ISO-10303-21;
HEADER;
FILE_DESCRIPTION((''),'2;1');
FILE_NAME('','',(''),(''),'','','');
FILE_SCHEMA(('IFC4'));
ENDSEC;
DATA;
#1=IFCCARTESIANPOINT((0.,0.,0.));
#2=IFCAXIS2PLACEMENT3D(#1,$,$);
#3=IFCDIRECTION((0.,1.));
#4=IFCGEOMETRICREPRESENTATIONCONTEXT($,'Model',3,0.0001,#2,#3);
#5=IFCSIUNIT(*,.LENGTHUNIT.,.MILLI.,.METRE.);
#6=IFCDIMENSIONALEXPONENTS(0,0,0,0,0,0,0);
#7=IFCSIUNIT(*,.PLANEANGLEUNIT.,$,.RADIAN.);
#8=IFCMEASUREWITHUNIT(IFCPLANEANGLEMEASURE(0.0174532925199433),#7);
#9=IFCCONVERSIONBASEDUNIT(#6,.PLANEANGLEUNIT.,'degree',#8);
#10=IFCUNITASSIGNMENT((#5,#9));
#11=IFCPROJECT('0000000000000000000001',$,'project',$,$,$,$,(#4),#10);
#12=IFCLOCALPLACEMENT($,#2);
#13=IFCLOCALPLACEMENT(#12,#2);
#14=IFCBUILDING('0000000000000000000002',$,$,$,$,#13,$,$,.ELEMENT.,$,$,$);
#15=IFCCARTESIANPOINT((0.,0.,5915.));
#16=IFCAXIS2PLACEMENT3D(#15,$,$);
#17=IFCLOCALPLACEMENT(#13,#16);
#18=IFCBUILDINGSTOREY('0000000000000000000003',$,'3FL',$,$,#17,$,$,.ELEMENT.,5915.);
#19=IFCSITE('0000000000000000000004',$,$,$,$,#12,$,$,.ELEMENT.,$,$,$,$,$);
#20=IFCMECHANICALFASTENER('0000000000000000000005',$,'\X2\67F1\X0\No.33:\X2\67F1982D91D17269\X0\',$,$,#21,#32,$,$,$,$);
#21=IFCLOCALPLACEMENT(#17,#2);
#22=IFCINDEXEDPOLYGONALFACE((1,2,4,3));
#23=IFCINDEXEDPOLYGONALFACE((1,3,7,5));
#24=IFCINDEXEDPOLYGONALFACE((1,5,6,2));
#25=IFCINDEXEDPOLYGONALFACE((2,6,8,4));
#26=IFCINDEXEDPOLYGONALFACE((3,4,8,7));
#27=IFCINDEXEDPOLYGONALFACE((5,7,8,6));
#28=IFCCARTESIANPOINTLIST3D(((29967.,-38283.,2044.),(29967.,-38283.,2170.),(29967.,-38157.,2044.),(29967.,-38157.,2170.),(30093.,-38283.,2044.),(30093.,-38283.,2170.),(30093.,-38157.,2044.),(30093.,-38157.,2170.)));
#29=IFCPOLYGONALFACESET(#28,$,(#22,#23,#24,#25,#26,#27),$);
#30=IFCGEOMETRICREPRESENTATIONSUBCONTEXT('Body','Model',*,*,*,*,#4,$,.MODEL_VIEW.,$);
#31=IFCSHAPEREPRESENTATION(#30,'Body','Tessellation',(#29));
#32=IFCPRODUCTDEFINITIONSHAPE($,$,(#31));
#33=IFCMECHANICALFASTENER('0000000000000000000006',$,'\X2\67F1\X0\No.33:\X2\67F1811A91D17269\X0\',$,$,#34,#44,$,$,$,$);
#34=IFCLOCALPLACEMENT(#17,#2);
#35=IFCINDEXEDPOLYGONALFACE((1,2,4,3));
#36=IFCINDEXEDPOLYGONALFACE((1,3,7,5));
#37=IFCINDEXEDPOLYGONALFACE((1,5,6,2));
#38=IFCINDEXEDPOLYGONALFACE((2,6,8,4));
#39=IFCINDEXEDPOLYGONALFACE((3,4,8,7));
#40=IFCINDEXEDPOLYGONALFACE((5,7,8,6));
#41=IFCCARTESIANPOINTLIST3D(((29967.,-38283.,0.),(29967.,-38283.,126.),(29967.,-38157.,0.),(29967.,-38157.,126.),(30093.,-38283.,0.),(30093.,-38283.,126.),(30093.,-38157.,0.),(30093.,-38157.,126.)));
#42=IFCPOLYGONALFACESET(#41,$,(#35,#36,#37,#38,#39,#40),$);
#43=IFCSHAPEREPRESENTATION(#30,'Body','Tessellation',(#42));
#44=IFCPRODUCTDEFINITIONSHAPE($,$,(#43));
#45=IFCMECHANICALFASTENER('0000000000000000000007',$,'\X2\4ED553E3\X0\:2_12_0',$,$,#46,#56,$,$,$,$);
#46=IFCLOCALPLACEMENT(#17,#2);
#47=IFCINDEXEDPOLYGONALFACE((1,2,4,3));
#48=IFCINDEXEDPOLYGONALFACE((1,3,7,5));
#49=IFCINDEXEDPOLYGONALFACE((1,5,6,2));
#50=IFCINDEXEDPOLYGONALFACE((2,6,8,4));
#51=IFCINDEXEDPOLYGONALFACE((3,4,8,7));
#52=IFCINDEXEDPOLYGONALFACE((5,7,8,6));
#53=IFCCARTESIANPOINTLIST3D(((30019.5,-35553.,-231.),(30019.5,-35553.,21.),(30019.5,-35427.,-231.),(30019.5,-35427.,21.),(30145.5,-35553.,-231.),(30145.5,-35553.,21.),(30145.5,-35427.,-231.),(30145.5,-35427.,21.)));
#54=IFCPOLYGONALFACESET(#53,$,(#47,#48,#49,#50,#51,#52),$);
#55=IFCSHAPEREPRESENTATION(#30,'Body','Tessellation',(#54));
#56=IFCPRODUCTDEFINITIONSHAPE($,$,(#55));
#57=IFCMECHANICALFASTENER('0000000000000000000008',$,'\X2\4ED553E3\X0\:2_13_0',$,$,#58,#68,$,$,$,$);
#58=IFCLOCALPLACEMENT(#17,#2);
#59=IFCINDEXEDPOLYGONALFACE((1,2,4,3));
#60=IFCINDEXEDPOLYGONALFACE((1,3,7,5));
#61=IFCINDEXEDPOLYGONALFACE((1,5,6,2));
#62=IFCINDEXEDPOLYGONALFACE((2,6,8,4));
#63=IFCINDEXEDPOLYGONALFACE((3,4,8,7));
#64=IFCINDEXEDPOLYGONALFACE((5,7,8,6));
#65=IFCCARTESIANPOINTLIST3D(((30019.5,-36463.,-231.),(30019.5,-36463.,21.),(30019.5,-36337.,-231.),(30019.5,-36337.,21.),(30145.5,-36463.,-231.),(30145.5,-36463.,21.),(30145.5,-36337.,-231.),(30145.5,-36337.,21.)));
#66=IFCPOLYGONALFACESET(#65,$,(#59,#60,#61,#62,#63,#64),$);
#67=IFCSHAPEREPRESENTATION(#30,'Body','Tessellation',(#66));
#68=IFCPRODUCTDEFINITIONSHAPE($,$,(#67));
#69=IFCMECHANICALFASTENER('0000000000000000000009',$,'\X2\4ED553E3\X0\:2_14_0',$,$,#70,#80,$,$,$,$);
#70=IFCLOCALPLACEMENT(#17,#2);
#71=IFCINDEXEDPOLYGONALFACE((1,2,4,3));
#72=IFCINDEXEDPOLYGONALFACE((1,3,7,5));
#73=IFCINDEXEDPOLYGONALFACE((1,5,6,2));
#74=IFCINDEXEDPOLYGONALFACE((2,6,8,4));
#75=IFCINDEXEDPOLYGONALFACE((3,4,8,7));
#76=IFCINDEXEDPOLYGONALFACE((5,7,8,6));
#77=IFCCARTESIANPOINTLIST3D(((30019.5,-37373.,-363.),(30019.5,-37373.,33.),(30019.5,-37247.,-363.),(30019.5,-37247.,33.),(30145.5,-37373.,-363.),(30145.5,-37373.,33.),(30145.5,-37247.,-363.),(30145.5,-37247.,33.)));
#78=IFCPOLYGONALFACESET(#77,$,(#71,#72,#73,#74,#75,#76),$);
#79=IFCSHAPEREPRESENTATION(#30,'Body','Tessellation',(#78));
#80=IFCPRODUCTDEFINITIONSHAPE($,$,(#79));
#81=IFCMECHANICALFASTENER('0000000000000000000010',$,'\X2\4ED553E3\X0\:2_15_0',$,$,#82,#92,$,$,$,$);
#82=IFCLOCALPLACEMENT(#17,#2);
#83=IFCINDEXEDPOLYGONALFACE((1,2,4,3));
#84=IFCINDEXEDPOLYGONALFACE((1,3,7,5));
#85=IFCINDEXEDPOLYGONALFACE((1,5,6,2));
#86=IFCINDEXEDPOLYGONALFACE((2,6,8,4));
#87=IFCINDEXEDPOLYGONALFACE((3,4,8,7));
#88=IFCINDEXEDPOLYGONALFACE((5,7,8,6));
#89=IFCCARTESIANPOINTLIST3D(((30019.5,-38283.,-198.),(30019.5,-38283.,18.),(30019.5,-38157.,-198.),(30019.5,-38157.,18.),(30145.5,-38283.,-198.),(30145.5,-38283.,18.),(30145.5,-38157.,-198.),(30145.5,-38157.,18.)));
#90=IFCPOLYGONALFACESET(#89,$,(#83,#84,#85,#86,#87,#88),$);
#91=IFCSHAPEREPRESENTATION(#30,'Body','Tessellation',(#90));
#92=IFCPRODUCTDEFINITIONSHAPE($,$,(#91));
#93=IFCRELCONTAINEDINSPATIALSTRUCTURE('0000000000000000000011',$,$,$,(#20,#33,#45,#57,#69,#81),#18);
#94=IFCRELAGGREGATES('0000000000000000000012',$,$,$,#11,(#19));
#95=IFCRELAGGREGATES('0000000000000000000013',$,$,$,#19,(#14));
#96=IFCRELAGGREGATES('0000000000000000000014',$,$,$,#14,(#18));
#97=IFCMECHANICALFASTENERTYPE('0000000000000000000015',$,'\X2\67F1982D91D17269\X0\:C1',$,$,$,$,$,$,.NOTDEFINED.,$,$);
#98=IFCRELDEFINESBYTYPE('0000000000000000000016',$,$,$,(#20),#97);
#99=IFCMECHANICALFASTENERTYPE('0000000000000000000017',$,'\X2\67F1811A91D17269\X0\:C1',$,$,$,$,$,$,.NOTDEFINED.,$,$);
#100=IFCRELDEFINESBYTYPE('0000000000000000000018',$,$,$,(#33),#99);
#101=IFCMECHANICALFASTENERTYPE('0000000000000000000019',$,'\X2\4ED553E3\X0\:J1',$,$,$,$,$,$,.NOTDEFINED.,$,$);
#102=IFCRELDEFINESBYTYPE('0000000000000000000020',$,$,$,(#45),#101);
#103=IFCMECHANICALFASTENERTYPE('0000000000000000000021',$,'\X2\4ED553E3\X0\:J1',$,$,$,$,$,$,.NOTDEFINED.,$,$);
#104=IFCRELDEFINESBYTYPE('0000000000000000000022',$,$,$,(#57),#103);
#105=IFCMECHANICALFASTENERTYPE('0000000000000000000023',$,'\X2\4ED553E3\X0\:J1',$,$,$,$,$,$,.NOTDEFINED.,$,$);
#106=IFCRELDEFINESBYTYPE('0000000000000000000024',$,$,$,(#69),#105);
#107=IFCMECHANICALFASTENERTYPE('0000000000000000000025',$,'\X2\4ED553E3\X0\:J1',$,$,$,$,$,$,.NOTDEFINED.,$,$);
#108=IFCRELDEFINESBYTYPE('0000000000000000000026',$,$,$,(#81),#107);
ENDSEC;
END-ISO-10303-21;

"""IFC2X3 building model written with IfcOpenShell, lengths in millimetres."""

from ifc_helpers import new_model, entity, si_unit, converted_unit, direction, frame, origin, origin_with_axes, origin_2d, place, context, subcontext, project, spatial, rectangle, extrude, type_object, element, save


model = new_model("IFC2X3")

# Units and contexts
model_context = context("Model", 3, precision=0.0001, world=origin(), true_north=direction((0.0, 1.0)))
body_context = subcontext(model_context, "Body", "Model", "MODEL_VIEW")
ifc_project = project(units=[si_unit("LENGTHUNIT", "METRE", prefix="MILLI"), converted_unit("PLANEANGLEUNIT", "degree", entity("IfcPlaneAngleMeasure", 0.0174532925199433), si_unit("PLANEANGLEUNIT", "RADIAN"), dimensions=[0, 0, 0, 0, 0, 0, 0])], contexts=[model_context])

# Site, building, storey
site_placement = place(None, origin())
site = spatial("IfcSite", under=ifc_project, at=site_placement, CompositionType="ELEMENT")
building_placement = place(site_placement, origin())
building = spatial("IfcBuilding", under=site, at=building_placement, CompositionType="ELEMENT")
storey_placement = place(building_placement, frame((0.0, 0.0, 5915.0)))
storey = spatial("IfcBuildingStorey", under=building, at=storey_placement, Name="3FL", CompositionType="ELEMENT", Elevation=5915.0)

# Mechanical fasteners
mechanical_fastener_type_1 = type_object("IfcMechanicalFastenerType", Name="柱頭金物:C1")
mechanical_fastener_1_placement = place(storey_placement, frame((30030.0, -38220.0, 2044.0)))
element("IfcMechanicalFastener", 1, at=mechanical_fastener_1_placement, inside=storey, type_object=mechanical_fastener_type_1, Name="柱No.33:柱頭金物", context=body_context, shape_type="SweptSolid", body=[
    extrude(rectangle(XDim=126.0, YDim=126.0, at=origin_2d()), origin_with_axes(), (0.0, 0.0, 1.0), 126.0),
])
mechanical_fastener_type_2 = type_object("IfcMechanicalFastenerType", Name="柱脚金物:C1")
mechanical_fastener_2_placement = place(storey_placement, frame((30030.0, -38220.0, 0.0)))
element("IfcMechanicalFastener", 2, at=mechanical_fastener_2_placement, inside=storey, type_object=mechanical_fastener_type_2, Name="柱No.33:柱脚金物", context=body_context, shape_type="SweptSolid", body=[
    extrude(rectangle(XDim=126.0, YDim=126.0, at=origin_2d()), origin_with_axes(), (0.0, 0.0, 1.0), 126.0),
])
mechanical_fastener_type_3 = type_object("IfcMechanicalFastenerType", Name="仕口:J1")
mechanical_fastener_3_placement = place(storey_placement, frame((30082.5, -35490.0, -231.0)))
element("IfcMechanicalFastener", 3, at=mechanical_fastener_3_placement, inside=storey, type_object=mechanical_fastener_type_3, Name="仕口:2_12_0", context=body_context, shape_type="SweptSolid", body=[
    extrude(rectangle(XDim=126.0, YDim=126.0, at=origin_2d()), origin_with_axes(), (0.0, 0.0, 1.0), 252.0),
])
mechanical_fastener_type_4 = type_object("IfcMechanicalFastenerType", Name="仕口:J1")
mechanical_fastener_4_placement = place(storey_placement, frame((30082.5, -36400.0, -231.0)))
element("IfcMechanicalFastener", 4, at=mechanical_fastener_4_placement, inside=storey, type_object=mechanical_fastener_type_4, Name="仕口:2_13_0", context=body_context, shape_type="SweptSolid", body=[
    extrude(rectangle(XDim=126.0, YDim=126.0, at=origin_2d()), origin_with_axes(), (0.0, 0.0, 1.0), 252.0),
])
mechanical_fastener_type_5 = type_object("IfcMechanicalFastenerType", Name="仕口:J1")
mechanical_fastener_5_placement = place(storey_placement, frame((30082.5, -37310.0, -363.0)))
element("IfcMechanicalFastener", 5, at=mechanical_fastener_5_placement, inside=storey, type_object=mechanical_fastener_type_5, Name="仕口:2_14_0", context=body_context, shape_type="SweptSolid", body=[
    extrude(rectangle(XDim=126.0, YDim=126.0, at=origin_2d()), origin_with_axes(), (0.0, 0.0, 1.0), 396.0),
])
mechanical_fastener_type_6 = type_object("IfcMechanicalFastenerType", Name="仕口:J1")
mechanical_fastener_6_placement = place(storey_placement, frame((30082.5, -38220.0, -198.0)))
element("IfcMechanicalFastener", 6, at=mechanical_fastener_6_placement, inside=storey, type_object=mechanical_fastener_type_6, Name="仕口:2_15_0", context=body_context, shape_type="SweptSolid", body=[
    extrude(rectangle(XDim=126.0, YDim=126.0, at=origin_2d()), origin_with_axes(), (0.0, 0.0, 1.0), 216.0),
])

save(model, "model.ifc")
